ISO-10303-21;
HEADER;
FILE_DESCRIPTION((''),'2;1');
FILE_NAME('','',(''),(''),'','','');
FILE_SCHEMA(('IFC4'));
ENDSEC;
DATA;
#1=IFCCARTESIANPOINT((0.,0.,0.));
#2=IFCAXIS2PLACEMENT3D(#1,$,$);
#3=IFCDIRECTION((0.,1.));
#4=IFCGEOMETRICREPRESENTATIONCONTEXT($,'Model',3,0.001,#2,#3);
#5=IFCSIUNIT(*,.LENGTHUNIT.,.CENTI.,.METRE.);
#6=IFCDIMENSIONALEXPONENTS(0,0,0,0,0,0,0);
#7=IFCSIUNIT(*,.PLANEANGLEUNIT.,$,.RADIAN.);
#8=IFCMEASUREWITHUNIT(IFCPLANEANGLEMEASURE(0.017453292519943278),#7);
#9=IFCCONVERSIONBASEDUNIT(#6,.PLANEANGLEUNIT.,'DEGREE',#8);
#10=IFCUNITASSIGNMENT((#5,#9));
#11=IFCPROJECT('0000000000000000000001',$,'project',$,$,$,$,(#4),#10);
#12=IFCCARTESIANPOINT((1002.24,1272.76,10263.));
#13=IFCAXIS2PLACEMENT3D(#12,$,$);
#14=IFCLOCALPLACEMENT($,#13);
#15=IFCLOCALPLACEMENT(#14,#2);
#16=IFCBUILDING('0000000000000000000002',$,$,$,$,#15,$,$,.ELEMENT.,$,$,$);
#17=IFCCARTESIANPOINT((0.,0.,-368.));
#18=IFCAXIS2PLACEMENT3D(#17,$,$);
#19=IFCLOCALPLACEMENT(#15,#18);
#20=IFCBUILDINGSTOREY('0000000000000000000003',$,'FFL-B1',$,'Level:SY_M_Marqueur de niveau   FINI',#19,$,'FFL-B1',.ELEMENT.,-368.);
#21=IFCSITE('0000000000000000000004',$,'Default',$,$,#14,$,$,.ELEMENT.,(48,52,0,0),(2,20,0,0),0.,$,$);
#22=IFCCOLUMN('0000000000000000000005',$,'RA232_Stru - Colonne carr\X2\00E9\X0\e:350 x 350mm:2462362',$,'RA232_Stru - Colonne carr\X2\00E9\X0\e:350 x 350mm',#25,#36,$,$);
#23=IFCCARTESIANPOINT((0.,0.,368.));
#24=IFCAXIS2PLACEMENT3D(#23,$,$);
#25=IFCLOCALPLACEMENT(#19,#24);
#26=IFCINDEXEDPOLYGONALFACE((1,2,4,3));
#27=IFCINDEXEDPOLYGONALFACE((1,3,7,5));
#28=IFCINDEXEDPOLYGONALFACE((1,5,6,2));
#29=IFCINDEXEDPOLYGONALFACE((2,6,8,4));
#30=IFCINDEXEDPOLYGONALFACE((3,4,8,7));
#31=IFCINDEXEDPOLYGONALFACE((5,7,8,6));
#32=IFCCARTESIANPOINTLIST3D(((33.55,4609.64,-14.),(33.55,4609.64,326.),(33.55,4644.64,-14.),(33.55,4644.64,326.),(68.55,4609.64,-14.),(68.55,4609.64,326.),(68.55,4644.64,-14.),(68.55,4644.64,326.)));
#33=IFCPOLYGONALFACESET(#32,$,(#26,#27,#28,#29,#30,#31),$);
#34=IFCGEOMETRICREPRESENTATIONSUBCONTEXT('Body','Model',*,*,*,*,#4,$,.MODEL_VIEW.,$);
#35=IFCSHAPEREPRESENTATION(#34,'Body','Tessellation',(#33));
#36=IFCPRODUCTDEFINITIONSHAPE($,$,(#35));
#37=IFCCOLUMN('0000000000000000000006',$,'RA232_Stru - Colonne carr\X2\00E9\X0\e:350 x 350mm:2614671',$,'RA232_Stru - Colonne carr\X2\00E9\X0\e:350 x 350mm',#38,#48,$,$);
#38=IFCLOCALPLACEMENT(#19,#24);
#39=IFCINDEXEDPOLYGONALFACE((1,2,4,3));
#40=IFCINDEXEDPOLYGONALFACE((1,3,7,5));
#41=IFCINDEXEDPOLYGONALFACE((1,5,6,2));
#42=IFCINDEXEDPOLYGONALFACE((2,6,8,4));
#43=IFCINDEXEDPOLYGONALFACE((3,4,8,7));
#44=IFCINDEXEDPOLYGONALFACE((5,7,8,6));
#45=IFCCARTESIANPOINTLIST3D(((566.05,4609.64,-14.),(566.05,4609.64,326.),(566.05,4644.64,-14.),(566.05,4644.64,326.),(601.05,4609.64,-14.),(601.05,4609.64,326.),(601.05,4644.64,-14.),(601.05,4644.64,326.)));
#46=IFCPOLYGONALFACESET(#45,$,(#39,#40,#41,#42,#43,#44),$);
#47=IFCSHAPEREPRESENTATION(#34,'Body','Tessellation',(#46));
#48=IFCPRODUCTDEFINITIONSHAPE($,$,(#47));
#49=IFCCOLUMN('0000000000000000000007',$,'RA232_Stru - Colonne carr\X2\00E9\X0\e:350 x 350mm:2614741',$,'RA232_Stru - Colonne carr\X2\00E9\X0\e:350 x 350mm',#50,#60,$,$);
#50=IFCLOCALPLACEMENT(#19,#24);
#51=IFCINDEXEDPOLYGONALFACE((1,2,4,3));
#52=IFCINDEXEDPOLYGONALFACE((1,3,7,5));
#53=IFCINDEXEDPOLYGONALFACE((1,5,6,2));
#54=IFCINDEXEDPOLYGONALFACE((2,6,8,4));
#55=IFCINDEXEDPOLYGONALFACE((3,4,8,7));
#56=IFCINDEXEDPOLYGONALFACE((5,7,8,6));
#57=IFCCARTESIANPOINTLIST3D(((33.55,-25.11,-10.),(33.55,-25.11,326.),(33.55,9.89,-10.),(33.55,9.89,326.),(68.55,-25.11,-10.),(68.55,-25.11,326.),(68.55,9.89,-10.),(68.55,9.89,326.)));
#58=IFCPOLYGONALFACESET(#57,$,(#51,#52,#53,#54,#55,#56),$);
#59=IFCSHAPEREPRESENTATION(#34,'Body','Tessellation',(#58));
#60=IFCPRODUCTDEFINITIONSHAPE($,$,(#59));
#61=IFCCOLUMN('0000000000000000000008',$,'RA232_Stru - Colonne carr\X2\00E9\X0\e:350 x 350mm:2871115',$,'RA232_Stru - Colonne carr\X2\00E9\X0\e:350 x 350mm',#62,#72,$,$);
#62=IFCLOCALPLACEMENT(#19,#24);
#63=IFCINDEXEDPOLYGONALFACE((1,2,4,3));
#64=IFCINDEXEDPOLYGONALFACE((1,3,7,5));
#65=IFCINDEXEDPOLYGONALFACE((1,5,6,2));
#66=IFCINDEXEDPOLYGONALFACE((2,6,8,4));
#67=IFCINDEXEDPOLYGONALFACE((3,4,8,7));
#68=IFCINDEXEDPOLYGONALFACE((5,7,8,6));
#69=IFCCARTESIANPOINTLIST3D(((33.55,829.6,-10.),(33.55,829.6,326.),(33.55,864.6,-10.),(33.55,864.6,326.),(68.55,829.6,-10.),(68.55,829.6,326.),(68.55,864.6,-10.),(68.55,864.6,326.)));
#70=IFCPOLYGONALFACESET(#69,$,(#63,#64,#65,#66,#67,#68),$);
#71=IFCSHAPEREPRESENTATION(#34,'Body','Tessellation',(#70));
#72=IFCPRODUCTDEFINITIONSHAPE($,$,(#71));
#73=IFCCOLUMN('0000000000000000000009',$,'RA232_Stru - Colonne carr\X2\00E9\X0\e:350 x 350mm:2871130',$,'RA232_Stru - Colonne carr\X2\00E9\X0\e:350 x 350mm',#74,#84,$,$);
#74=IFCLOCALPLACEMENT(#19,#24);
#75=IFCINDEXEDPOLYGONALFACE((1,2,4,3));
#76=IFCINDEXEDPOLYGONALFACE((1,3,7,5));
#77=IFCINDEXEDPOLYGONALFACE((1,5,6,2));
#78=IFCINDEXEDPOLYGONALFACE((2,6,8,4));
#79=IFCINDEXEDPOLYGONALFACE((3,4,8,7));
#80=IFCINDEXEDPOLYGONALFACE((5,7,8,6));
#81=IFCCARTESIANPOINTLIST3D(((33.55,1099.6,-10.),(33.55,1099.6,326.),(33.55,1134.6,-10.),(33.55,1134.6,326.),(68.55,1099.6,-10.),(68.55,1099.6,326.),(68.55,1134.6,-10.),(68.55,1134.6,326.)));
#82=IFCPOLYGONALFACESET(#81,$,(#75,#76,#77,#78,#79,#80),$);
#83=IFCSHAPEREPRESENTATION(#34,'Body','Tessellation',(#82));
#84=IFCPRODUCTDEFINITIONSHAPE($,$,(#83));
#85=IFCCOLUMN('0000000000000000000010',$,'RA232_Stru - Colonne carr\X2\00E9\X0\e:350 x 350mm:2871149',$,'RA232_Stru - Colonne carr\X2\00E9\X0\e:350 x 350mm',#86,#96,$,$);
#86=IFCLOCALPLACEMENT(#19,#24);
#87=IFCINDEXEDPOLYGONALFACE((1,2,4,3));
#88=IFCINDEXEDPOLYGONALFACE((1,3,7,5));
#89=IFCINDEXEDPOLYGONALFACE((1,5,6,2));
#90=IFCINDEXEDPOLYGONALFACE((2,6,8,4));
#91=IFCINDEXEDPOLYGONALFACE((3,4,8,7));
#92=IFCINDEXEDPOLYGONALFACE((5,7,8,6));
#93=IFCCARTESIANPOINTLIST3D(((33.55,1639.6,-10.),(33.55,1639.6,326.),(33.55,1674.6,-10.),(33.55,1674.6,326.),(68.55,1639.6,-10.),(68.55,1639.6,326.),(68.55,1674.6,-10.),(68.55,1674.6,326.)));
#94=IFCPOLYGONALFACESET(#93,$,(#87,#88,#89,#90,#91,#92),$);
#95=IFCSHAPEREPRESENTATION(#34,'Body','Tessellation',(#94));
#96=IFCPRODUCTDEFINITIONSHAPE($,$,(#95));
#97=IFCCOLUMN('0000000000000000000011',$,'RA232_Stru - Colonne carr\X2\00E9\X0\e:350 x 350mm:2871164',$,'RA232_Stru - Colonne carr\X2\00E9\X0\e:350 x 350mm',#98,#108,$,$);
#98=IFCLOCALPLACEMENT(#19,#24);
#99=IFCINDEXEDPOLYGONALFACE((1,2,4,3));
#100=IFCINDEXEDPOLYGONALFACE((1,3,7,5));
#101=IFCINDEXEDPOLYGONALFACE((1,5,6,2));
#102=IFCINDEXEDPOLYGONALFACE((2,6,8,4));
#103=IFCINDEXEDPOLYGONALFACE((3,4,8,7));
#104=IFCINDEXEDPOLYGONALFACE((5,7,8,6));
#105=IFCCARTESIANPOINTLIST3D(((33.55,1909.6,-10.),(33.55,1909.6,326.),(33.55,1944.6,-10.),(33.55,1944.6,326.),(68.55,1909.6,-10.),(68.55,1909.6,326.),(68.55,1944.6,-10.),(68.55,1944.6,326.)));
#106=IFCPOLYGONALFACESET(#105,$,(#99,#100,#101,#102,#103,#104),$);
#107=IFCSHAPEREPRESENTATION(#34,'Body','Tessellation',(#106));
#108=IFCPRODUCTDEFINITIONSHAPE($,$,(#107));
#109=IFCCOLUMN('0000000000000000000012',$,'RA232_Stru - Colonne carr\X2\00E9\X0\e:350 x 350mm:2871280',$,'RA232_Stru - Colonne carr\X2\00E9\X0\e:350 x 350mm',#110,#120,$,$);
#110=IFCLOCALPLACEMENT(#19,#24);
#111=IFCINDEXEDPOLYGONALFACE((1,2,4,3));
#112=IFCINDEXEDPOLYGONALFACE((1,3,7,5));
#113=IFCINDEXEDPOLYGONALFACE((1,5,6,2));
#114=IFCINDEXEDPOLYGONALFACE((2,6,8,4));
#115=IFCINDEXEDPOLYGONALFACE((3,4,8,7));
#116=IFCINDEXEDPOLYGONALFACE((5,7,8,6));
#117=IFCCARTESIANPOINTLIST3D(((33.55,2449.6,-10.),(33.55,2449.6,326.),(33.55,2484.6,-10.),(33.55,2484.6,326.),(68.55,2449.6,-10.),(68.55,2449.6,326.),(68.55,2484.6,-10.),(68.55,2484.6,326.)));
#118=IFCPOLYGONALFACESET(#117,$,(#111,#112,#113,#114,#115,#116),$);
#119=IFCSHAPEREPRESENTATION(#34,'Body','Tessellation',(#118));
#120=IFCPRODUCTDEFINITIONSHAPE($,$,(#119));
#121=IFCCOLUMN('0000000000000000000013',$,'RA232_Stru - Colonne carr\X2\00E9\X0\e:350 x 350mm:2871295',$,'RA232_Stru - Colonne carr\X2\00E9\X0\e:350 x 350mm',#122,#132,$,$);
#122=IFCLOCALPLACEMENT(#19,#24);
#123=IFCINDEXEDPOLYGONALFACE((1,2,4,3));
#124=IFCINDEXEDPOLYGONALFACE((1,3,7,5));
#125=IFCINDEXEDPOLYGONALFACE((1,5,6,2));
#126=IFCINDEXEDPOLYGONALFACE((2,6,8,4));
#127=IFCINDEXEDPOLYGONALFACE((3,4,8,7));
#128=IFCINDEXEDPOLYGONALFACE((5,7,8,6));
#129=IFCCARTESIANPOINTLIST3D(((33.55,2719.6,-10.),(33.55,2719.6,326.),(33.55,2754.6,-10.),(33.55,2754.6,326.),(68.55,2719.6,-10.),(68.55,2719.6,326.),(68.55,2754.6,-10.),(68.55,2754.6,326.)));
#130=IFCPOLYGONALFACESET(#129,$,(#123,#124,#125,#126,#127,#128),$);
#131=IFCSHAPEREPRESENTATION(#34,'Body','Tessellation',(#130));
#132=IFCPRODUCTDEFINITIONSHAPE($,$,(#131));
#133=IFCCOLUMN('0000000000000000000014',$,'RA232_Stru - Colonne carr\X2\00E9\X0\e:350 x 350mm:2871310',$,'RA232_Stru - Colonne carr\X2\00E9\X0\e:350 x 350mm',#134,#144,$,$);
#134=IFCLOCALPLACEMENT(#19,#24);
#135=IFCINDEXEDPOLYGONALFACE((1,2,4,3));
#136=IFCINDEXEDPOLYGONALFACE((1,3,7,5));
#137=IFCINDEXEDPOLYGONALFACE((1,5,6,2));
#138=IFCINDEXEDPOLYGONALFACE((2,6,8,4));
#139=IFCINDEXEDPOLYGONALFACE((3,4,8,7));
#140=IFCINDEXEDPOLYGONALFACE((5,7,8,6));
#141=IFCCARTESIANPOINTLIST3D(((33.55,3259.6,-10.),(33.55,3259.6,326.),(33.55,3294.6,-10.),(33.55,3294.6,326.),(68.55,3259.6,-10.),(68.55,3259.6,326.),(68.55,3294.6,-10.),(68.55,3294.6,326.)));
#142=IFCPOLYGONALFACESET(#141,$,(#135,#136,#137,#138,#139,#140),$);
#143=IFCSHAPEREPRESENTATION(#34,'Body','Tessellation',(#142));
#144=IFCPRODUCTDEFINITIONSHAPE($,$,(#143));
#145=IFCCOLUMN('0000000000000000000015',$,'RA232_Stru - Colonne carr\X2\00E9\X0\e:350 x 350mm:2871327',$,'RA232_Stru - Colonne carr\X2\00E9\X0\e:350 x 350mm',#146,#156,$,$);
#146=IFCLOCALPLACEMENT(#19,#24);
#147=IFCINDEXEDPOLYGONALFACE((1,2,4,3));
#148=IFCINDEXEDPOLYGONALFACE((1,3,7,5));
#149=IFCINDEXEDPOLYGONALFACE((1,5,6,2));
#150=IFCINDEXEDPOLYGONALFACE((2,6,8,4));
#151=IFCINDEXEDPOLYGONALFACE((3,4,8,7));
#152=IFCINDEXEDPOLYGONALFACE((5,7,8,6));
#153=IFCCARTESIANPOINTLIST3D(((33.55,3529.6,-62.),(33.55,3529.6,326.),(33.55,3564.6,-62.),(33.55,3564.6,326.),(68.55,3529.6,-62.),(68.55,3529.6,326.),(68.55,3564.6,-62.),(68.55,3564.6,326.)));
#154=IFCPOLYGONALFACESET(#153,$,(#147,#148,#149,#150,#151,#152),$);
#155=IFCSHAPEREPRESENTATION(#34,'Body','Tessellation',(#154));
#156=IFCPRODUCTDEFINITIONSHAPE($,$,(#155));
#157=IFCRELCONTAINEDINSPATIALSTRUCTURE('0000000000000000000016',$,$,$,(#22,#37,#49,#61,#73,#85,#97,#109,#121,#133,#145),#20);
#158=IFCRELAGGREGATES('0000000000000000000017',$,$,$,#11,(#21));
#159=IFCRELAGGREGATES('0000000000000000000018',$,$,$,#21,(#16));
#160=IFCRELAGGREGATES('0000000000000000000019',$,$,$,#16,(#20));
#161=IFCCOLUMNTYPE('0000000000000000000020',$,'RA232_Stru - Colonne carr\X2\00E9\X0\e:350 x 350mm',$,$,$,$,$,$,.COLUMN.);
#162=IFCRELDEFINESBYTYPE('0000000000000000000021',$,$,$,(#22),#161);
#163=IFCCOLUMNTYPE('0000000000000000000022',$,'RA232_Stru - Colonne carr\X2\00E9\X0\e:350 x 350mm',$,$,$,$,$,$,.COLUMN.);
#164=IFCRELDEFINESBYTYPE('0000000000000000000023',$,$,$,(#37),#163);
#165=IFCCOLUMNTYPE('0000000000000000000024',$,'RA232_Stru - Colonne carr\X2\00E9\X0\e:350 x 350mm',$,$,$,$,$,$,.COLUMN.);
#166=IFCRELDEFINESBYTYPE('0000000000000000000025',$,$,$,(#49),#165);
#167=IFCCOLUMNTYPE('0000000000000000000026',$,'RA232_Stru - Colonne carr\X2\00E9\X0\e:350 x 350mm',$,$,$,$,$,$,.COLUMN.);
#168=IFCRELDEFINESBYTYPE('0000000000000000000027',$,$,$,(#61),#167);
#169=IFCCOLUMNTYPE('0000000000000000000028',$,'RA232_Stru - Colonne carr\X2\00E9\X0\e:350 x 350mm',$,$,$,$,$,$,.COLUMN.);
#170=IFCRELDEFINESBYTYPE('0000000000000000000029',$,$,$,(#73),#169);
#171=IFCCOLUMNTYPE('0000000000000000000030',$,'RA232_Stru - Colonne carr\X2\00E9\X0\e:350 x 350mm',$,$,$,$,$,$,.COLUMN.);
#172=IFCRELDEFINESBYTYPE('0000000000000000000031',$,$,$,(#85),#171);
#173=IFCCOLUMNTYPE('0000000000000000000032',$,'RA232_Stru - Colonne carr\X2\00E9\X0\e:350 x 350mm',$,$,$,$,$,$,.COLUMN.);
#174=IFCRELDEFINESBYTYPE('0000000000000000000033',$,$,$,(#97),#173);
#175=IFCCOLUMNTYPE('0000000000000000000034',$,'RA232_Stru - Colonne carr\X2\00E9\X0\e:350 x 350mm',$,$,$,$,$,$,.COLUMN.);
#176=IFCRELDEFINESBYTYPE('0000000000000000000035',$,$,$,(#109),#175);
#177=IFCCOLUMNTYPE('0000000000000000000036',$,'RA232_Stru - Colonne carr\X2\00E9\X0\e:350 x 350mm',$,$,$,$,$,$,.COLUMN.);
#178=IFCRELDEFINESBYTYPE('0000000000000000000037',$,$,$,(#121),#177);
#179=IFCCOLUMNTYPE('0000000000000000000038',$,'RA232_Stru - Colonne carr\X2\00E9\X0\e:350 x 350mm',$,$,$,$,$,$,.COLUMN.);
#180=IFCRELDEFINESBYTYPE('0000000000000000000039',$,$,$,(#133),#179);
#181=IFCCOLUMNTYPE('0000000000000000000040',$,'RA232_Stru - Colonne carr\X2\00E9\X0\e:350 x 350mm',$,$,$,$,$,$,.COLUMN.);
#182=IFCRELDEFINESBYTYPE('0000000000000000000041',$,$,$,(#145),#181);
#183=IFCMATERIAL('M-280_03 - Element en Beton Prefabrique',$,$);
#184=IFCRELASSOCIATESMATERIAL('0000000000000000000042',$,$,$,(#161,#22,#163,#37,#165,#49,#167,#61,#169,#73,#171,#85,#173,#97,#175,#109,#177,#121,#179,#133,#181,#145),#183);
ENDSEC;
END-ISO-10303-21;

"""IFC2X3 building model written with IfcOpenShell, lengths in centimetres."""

from ifc_helpers import new_model, entity, si_unit, converted_unit, direction, frame, frame_2d, origin, origin_2d_with_axis, place, context, subcontext, project, spatial, rectangle, extrude, source, transform, mapped, material, type_object, type_shapes, element, save


model = new_model("IFC2X3")

# Units and contexts
model_context = context("Model", 3, precision=0.001, world=origin(), true_north=direction((0.0, 1.0)))
body_context = subcontext(model_context, "Body", "Model", "MODEL_VIEW")
ifc_project = project(units=[si_unit("LENGTHUNIT", "METRE", prefix="CENTI"), converted_unit("PLANEANGLEUNIT", "DEGREE", entity("IfcPlaneAngleMeasure", 0.017453292519943278), si_unit("PLANEANGLEUNIT", "RADIAN"), dimensions=[0, 0, 0, 0, 0, 0, 0])], contexts=[model_context])

# Site, building, storey
site_placement = place(None, frame((1002.24, 1272.76, 10263.0)))
site = spatial("IfcSite", under=ifc_project, at=site_placement, Name="Default", CompositionType="ELEMENT", RefLatitude=(48, 52, 0, 0), RefLongitude=(2, 20, 0, 0), RefElevation=0.0)
building_placement = place(site_placement, origin())
building = spatial("IfcBuilding", under=site, at=building_placement, CompositionType="ELEMENT")
storey_placement = place(building_placement, frame((0.0, 0.0, -368.0)))
storey = spatial("IfcBuildingStorey", under=building, at=storey_placement, Name="FFL-B1", ObjectType="Level:SY_M_Marqueur de niveau   FINI", LongName="FFL-B1", CompositionType="ELEMENT", Elevation=-368.0)

# Columns
ifc_material_1 = material(Name="M-280_03 - Element en Beton Prefabrique")
column_type_1 = type_object("IfcColumnType", Name="RA232_Stru - Colonne carrée:350 x 350mm", PredefinedType="COLUMN", material=ifc_material_1)
shared_shape_1 = source(origin(), body_context, "Body", "SweptSolid", [
    extrude(rectangle(XDim=35.0, YDim=35.0, at=frame_2d((0.0, 0.0), x_axis=(1.0, 0.0))), frame((51.05, 4627.14, -14.0), z_axis=(0.0, 0.0, 1.0), x_axis=(-1.0, 0.0, 0.0)), (0.0, 0.0, 1.0), 340.0),
])
type_shapes(column_type_1, [shared_shape_1])
column_1_placement = place(storey_placement, frame((0.0, 0.0, 368.0)))
element("IfcColumn", 1, at=column_1_placement, inside=storey, type_object=column_type_1, material=ifc_material_1, Name="RA232_Stru - Colonne carrée:350 x 350mm:2462362", ObjectType="RA232_Stru - Colonne carrée:350 x 350mm", context=body_context, shape_type="MappedRepresentation", body=[
    mapped(shared_shape_1, transform((0.0, 0.0, 0.0), scale=1.0)),
])
column_type_2 = type_object("IfcColumnType", Name="RA232_Stru - Colonne carrée:350 x 350mm", PredefinedType="COLUMN", material=ifc_material_1)
shared_shape_2 = source(origin(), body_context, "Body", "SweptSolid", [
    extrude(rectangle(XDim=35.0, YDim=35.0, at=frame_2d((0.0, 0.0), x_axis=(1.0, 0.0))), frame((583.55, 4627.14, -14.0), z_axis=(0.0, 0.0, 1.0), x_axis=(-1.0, 0.0, 0.0)), (0.0, 0.0, 1.0), 340.0),
])
type_shapes(column_type_2, [shared_shape_2])
column_2_placement = place(storey_placement, frame((0.0, 0.0, 368.0)))
element("IfcColumn", 2, at=column_2_placement, inside=storey, type_object=column_type_2, material=ifc_material_1, Name="RA232_Stru - Colonne carrée:350 x 350mm:2614671", ObjectType="RA232_Stru - Colonne carrée:350 x 350mm", context=body_context, shape_type="MappedRepresentation", body=[
    mapped(shared_shape_2, transform((0.0, 0.0, 0.0), scale=1.0)),
])
column_type_3 = type_object("IfcColumnType", Name="RA232_Stru - Colonne carrée:350 x 350mm", PredefinedType="COLUMN", material=ifc_material_1)
shared_shape_3 = source(origin(), body_context, "Body", "SweptSolid", [
    extrude(rectangle(XDim=35.0, YDim=35.0, at=origin_2d_with_axis()), frame((51.05, -7.61, -10.0), z_axis=(0.0, 0.0, 1.0), x_axis=(-1.0, 0.0, 0.0)), (0.0, 0.0, 1.0), 336.0),
])
type_shapes(column_type_3, [shared_shape_3])
column_3_placement = place(storey_placement, frame((0.0, 0.0, 368.0)))
element("IfcColumn", 3, at=column_3_placement, inside=storey, type_object=column_type_3, material=ifc_material_1, Name="RA232_Stru - Colonne carrée:350 x 350mm:2614741", ObjectType="RA232_Stru - Colonne carrée:350 x 350mm", context=body_context, shape_type="MappedRepresentation", body=[
    mapped(shared_shape_3, transform((0.0, 0.0, 0.0), scale=1.0)),
])
column_type_4 = type_object("IfcColumnType", Name="RA232_Stru - Colonne carrée:350 x 350mm", PredefinedType="COLUMN", material=ifc_material_1)
shared_shape_4 = source(origin(), body_context, "Body", "SweptSolid", [
    extrude(rectangle(XDim=35.0, YDim=35.0, at=frame_2d((0.0, 0.0), x_axis=(1.0, 0.0))), frame((51.05, 847.1, -10.0), z_axis=(0.0, 0.0, 1.0), x_axis=(-1.0, 0.0, 0.0)), (0.0, 0.0, 1.0), 336.0),
])
type_shapes(column_type_4, [shared_shape_4])
column_4_placement = place(storey_placement, frame((0.0, 0.0, 368.0)))
element("IfcColumn", 4, at=column_4_placement, inside=storey, type_object=column_type_4, material=ifc_material_1, Name="RA232_Stru - Colonne carrée:350 x 350mm:2871115", ObjectType="RA232_Stru - Colonne carrée:350 x 350mm", context=body_context, shape_type="MappedRepresentation", body=[
    mapped(shared_shape_4, transform((0.0, 0.0, 0.0), scale=1.0)),
])
column_type_5 = type_object("IfcColumnType", Name="RA232_Stru - Colonne carrée:350 x 350mm", PredefinedType="COLUMN", material=ifc_material_1)
shared_shape_5 = source(origin(), body_context, "Body", "SweptSolid", [
    extrude(rectangle(XDim=35.0, YDim=35.0, at=frame_2d((0.0, 0.0), x_axis=(1.0, 0.0))), frame((51.05, 1117.1, -10.0), z_axis=(0.0, 0.0, 1.0), x_axis=(-1.0, 0.0, 0.0)), (0.0, 0.0, 1.0), 336.0),
])
type_shapes(column_type_5, [shared_shape_5])
column_5_placement = place(storey_placement, frame((0.0, 0.0, 368.0)))
element("IfcColumn", 5, at=column_5_placement, inside=storey, type_object=column_type_5, material=ifc_material_1, Name="RA232_Stru - Colonne carrée:350 x 350mm:2871130", ObjectType="RA232_Stru - Colonne carrée:350 x 350mm", context=body_context, shape_type="MappedRepresentation", body=[
    mapped(shared_shape_5, transform((0.0, 0.0, 0.0), scale=1.0)),
])
column_type_6 = type_object("IfcColumnType", Name="RA232_Stru - Colonne carrée:350 x 350mm", PredefinedType="COLUMN", material=ifc_material_1)
shared_shape_6 = source(origin(), body_context, "Body", "SweptSolid", [
    extrude(rectangle(XDim=35.0, YDim=35.0, at=frame_2d((0.0, 0.0), x_axis=(1.0, 0.0))), frame((51.05, 1657.1, -10.0), z_axis=(0.0, 0.0, 1.0), x_axis=(-1.0, 0.0, 0.0)), (0.0, 0.0, 1.0), 336.0),
])
type_shapes(column_type_6, [shared_shape_6])
column_6_placement = place(storey_placement, frame((0.0, 0.0, 368.0)))
element("IfcColumn", 6, at=column_6_placement, inside=storey, type_object=column_type_6, material=ifc_material_1, Name="RA232_Stru - Colonne carrée:350 x 350mm:2871149", ObjectType="RA232_Stru - Colonne carrée:350 x 350mm", context=body_context, shape_type="MappedRepresentation", body=[
    mapped(shared_shape_6, transform((0.0, 0.0, 0.0), scale=1.0)),
])
column_type_7 = type_object("IfcColumnType", Name="RA232_Stru - Colonne carrée:350 x 350mm", PredefinedType="COLUMN", material=ifc_material_1)
shared_shape_7 = source(origin(), body_context, "Body", "SweptSolid", [
    extrude(rectangle(XDim=35.0, YDim=35.0, at=frame_2d((0.0, 0.0), x_axis=(1.0, 0.0))), frame((51.05, 1927.1, -10.0), z_axis=(0.0, 0.0, 1.0), x_axis=(-1.0, 0.0, 0.0)), (0.0, 0.0, 1.0), 336.0),
])
type_shapes(column_type_7, [shared_shape_7])
column_7_placement = place(storey_placement, frame((0.0, 0.0, 368.0)))
element("IfcColumn", 7, at=column_7_placement, inside=storey, type_object=column_type_7, material=ifc_material_1, Name="RA232_Stru - Colonne carrée:350 x 350mm:2871164", ObjectType="RA232_Stru - Colonne carrée:350 x 350mm", context=body_context, shape_type="MappedRepresentation", body=[
    mapped(shared_shape_7, transform((0.0, 0.0, 0.0), scale=1.0)),
])
column_type_8 = type_object("IfcColumnType", Name="RA232_Stru - Colonne carrée:350 x 350mm", PredefinedType="COLUMN", material=ifc_material_1)
shared_shape_8 = source(origin(), body_context, "Body", "SweptSolid", [
    extrude(rectangle(XDim=35.0, YDim=35.0, at=origin_2d_with_axis()), frame((51.05, 2467.1, -10.0), z_axis=(0.0, 0.0, 1.0), x_axis=(-1.0, 0.0, 0.0)), (0.0, 0.0, 1.0), 336.0),
])
type_shapes(column_type_8, [shared_shape_8])
column_8_placement = place(storey_placement, frame((0.0, 0.0, 368.0)))
element("IfcColumn", 8, at=column_8_placement, inside=storey, type_object=column_type_8, material=ifc_material_1, Name="RA232_Stru - Colonne carrée:350 x 350mm:2871280", ObjectType="RA232_Stru - Colonne carrée:350 x 350mm", context=body_context, shape_type="MappedRepresentation", body=[
    mapped(shared_shape_8, transform((0.0, 0.0, 0.0), scale=1.0)),
])
column_type_9 = type_object("IfcColumnType", Name="RA232_Stru - Colonne carrée:350 x 350mm", PredefinedType="COLUMN", material=ifc_material_1)
shared_shape_9 = source(origin(), body_context, "Body", "SweptSolid", [
    extrude(rectangle(XDim=35.0, YDim=35.0, at=origin_2d_with_axis()), frame((51.05, 2737.1, -10.0), z_axis=(0.0, 0.0, 1.0), x_axis=(-1.0, 0.0, 0.0)), (0.0, 0.0, 1.0), 336.0),
])
type_shapes(column_type_9, [shared_shape_9])
column_9_placement = place(storey_placement, frame((0.0, 0.0, 368.0)))
element("IfcColumn", 9, at=column_9_placement, inside=storey, type_object=column_type_9, material=ifc_material_1, Name="RA232_Stru - Colonne carrée:350 x 350mm:2871295", ObjectType="RA232_Stru - Colonne carrée:350 x 350mm", context=body_context, shape_type="MappedRepresentation", body=[
    mapped(shared_shape_9, transform((0.0, 0.0, 0.0), scale=1.0)),
])
column_type_10 = type_object("IfcColumnType", Name="RA232_Stru - Colonne carrée:350 x 350mm", PredefinedType="COLUMN", material=ifc_material_1)
shared_shape_10 = source(origin(), body_context, "Body", "SweptSolid", [
    extrude(rectangle(XDim=35.0, YDim=35.0, at=frame_2d((0.0, 0.0), x_axis=(1.0, 0.0))), frame((51.05, 3277.1, -10.0), z_axis=(0.0, 0.0, 1.0), x_axis=(-1.0, 0.0, 0.0)), (0.0, 0.0, 1.0), 336.0),
])
type_shapes(column_type_10, [shared_shape_10])
column_10_placement = place(storey_placement, frame((0.0, 0.0, 368.0)))
element("IfcColumn", 10, at=column_10_placement, inside=storey, type_object=column_type_10, material=ifc_material_1, Name="RA232_Stru - Colonne carrée:350 x 350mm:2871310", ObjectType="RA232_Stru - Colonne carrée:350 x 350mm", context=body_context, shape_type="MappedRepresentation", body=[
    mapped(shared_shape_10, transform((0.0, 0.0, 0.0), scale=1.0)),
])
column_type_11 = type_object("IfcColumnType", Name="RA232_Stru - Colonne carrée:350 x 350mm", PredefinedType="COLUMN", material=ifc_material_1)
shared_shape_11 = source(origin(), body_context, "Body", "SweptSolid", [
    extrude(rectangle(XDim=35.0, YDim=35.0, at=origin_2d_with_axis()), frame((51.05, 3547.1, -62.0), z_axis=(0.0, 0.0, 1.0), x_axis=(-1.0, 0.0, 0.0)), (0.0, 0.0, 1.0), 388.0),
])
type_shapes(column_type_11, [shared_shape_11])
column_11_placement = place(storey_placement, frame((0.0, 0.0, 368.0)))
element("IfcColumn", 11, at=column_11_placement, inside=storey, type_object=column_type_11, material=ifc_material_1, Name="RA232_Stru - Colonne carrée:350 x 350mm:2871327", ObjectType="RA232_Stru - Colonne carrée:350 x 350mm", context=body_context, shape_type="MappedRepresentation", body=[
    mapped(shared_shape_11, transform((0.0, 0.0, 0.0), scale=1.0)),
])

save(model, "model.ifc")
